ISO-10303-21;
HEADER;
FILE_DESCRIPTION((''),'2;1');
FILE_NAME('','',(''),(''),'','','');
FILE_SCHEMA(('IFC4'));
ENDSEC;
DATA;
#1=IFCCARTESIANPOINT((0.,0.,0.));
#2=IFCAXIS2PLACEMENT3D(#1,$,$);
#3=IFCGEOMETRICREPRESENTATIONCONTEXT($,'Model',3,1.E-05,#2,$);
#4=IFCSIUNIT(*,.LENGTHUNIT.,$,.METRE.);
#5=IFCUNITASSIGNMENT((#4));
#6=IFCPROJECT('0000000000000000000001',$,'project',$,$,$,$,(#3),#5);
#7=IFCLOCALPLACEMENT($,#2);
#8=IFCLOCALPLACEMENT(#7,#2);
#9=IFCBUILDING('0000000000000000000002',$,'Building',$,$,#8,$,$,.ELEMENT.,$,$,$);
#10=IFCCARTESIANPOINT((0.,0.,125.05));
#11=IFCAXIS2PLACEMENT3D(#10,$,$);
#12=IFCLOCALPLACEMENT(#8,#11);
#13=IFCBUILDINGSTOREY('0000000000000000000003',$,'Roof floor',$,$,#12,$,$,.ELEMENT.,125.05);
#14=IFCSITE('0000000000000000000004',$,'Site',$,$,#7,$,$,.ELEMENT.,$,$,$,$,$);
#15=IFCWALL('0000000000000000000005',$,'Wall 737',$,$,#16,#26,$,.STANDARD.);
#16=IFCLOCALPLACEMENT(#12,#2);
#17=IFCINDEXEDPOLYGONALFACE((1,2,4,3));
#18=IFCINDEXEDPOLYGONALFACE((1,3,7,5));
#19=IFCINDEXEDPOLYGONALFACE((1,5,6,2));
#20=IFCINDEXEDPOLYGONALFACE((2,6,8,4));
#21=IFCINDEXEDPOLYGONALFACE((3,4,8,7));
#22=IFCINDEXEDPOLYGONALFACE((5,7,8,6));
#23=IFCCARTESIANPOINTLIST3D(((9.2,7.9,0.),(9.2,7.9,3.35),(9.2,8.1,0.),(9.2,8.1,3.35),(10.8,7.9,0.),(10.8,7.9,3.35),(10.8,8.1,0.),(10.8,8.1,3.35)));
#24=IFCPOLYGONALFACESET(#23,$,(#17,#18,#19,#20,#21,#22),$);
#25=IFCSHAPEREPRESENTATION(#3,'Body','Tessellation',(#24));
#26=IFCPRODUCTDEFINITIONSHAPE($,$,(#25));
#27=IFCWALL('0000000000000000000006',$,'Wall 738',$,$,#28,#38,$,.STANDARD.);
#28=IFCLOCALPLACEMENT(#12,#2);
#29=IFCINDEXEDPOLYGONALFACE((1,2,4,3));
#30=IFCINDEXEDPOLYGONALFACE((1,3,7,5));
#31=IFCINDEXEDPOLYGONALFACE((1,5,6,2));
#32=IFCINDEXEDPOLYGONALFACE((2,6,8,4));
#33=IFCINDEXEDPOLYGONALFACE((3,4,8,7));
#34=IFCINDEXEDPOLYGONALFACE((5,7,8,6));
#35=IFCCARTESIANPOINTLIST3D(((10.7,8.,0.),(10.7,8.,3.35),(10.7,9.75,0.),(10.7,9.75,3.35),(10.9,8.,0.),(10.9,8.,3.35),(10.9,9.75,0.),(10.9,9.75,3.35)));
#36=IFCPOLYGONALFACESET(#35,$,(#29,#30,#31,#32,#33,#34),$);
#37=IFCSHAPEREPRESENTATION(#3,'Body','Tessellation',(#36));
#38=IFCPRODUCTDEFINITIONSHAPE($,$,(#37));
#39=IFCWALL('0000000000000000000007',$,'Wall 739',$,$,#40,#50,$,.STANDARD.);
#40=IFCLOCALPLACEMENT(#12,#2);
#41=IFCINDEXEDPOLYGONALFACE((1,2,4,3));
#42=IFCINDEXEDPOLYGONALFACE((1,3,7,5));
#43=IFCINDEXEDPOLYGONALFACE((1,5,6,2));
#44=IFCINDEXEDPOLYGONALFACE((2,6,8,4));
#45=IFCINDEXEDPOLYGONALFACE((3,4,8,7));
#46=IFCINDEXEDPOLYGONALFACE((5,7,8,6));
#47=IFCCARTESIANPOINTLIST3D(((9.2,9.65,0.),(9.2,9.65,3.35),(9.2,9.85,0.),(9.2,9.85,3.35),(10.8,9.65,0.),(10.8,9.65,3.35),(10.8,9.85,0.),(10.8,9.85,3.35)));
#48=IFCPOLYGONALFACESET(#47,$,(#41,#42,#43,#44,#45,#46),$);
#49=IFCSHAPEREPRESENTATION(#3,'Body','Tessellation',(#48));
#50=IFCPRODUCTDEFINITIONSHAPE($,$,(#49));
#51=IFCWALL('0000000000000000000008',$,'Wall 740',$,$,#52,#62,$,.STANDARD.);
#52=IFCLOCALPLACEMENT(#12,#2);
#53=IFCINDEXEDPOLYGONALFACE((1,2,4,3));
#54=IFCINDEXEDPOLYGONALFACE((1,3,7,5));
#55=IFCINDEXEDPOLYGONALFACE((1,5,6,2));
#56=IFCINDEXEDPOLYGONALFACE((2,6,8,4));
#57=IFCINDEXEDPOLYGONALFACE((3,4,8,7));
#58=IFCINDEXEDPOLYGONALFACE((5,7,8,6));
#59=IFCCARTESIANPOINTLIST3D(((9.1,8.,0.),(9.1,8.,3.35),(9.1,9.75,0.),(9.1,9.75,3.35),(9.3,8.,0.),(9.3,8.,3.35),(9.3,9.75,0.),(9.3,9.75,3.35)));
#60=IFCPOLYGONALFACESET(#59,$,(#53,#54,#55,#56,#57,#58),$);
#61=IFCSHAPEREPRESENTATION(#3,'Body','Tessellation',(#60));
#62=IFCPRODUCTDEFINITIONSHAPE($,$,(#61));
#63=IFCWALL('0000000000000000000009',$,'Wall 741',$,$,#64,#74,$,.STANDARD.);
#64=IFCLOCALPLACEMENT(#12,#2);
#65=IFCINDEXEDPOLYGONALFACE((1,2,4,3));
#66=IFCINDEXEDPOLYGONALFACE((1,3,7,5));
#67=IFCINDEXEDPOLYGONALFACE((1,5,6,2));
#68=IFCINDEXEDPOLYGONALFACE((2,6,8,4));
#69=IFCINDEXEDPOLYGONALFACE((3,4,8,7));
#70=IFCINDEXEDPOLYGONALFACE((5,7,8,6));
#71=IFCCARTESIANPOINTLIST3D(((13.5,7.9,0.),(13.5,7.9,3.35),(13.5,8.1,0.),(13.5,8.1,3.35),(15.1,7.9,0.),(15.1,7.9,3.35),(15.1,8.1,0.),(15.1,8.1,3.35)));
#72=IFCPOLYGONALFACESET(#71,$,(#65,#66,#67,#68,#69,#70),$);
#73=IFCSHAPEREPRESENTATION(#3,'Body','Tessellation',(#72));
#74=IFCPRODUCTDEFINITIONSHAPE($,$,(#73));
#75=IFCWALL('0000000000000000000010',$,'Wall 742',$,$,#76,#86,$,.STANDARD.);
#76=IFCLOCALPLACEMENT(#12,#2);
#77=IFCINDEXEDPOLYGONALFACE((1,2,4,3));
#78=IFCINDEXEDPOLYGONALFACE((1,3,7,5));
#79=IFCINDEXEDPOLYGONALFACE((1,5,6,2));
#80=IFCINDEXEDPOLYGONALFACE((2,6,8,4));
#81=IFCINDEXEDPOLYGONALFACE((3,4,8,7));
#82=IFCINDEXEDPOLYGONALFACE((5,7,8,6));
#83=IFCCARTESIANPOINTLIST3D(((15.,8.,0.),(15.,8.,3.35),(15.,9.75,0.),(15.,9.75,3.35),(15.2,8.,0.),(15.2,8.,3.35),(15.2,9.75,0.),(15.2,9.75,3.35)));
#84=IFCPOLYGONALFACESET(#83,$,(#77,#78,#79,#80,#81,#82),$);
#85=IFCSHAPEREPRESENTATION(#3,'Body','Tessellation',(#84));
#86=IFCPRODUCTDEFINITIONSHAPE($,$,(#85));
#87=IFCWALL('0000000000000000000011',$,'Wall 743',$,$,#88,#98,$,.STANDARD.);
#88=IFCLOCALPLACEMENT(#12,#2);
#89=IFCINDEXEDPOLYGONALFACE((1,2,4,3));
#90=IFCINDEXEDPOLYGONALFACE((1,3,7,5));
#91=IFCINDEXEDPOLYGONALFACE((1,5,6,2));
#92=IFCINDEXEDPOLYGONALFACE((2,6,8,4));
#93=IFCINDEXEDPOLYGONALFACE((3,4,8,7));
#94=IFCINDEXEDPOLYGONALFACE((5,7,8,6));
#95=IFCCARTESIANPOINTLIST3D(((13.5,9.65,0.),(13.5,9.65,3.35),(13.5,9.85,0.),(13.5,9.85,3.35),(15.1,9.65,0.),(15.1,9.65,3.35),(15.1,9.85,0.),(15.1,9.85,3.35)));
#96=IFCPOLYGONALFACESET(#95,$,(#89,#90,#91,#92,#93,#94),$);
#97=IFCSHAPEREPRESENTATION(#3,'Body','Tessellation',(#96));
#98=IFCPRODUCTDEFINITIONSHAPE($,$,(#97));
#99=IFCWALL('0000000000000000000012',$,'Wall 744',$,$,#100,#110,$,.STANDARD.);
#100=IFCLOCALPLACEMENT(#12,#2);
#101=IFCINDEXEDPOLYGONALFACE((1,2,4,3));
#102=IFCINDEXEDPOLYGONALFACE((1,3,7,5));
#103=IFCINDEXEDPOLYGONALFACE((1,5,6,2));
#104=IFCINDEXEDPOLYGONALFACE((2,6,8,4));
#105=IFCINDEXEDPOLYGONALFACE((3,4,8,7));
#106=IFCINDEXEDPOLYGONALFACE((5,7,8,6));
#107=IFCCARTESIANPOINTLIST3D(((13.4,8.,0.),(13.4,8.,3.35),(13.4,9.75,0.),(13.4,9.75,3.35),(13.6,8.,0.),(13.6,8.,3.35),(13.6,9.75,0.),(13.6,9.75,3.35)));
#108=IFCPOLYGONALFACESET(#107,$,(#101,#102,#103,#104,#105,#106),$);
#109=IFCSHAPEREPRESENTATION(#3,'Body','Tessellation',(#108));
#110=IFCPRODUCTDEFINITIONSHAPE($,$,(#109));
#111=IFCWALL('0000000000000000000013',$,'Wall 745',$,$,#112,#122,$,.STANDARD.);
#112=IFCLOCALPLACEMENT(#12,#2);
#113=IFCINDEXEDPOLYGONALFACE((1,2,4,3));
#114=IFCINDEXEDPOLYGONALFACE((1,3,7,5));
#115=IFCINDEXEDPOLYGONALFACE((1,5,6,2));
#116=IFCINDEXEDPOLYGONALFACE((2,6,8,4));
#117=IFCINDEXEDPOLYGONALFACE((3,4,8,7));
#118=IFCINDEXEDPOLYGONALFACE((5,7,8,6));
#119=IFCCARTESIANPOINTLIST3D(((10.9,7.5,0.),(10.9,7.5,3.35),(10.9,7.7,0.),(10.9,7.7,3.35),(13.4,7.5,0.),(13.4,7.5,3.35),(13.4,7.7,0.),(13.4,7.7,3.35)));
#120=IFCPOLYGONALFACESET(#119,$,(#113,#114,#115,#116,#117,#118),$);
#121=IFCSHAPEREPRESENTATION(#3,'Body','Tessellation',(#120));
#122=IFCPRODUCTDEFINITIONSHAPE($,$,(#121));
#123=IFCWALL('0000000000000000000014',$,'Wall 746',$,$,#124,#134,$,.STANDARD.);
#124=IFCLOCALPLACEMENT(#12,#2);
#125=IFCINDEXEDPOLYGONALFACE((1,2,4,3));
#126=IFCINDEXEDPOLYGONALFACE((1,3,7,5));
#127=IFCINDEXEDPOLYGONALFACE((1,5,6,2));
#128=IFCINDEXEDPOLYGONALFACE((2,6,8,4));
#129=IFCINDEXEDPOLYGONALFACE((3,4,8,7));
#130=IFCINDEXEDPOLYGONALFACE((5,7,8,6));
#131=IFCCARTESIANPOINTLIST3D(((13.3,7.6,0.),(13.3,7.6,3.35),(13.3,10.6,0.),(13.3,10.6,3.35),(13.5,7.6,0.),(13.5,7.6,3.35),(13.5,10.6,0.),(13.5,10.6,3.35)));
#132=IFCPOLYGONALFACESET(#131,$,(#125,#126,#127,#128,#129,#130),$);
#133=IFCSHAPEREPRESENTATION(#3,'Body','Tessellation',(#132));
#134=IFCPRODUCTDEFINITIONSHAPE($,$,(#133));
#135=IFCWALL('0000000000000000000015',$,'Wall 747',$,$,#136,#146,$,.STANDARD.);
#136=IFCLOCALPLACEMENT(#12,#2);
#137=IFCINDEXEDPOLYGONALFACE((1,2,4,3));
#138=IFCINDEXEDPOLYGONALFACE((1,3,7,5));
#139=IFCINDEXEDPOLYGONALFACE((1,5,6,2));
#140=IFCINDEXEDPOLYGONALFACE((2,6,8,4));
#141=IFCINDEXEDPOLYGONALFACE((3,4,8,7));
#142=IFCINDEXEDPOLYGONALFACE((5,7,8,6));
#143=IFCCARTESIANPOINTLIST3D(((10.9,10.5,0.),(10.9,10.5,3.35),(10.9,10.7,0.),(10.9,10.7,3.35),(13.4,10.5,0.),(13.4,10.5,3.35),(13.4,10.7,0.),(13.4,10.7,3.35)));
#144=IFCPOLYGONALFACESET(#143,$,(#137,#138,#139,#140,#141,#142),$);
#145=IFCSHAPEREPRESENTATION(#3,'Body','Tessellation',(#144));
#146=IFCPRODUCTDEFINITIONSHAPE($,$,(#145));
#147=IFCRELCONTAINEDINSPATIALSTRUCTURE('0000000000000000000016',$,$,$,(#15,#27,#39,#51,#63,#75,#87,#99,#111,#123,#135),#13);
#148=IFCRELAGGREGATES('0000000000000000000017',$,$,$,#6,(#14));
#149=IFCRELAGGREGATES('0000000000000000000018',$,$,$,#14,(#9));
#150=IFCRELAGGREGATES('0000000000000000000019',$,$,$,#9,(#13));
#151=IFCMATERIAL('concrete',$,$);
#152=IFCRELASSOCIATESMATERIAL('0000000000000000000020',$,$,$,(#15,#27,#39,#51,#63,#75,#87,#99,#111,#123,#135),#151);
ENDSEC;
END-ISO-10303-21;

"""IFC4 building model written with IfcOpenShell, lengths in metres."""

from ifc_helpers import new_model, si_unit, frame, frame_2d, origin, place, context, project, spatial, rectangle, extrude, material, element, save


model = new_model("IFC4")

# Units and contexts
model_context = context("Model", 3, precision=1e-05, world=origin())
ifc_project = project(units=[si_unit("LENGTHUNIT", "METRE")], contexts=[model_context])

# Site, building, storey
site_placement = place(None, origin())
site = spatial("IfcSite", under=ifc_project, at=site_placement, Name="Site", CompositionType="ELEMENT")
building_placement = place(site_placement, origin())
building = spatial("IfcBuilding", under=site, at=building_placement, Name="Building", CompositionType="ELEMENT")
storey_placement = place(building_placement, frame((0.0, 0.0, 125.05)))
storey = spatial("IfcBuildingStorey", under=building, at=storey_placement, Name="Roof floor", CompositionType="ELEMENT", Elevation=125.05)

# Shared definitions
ifc_material = material(Name="concrete")

# Walls
wall_1_placement = place(storey_placement, frame((9.2, 8.0, 0.0), z_axis=(0.0, 0.0, 1.0), x_axis=(1.0, 0.0, 0.0)))
element("IfcWall", 1, at=wall_1_placement, inside=storey, material=ifc_material, Name="Wall 737", PredefinedType="STANDARD", context=model_context, shape_type="SweptSolid", body=[
    extrude(rectangle(XDim=1.6, YDim=0.2, at=frame_2d((0.8, 0.0))), origin(), (0.0, 0.0, 1.0), 3.35),
])
wall_2_placement = place(storey_placement, frame((10.8, 8.0, 0.0), z_axis=(0.0, 0.0, 1.0), x_axis=(0.0, 1.0, 0.0)))
element("IfcWall", 2, at=wall_2_placement, inside=storey, material=ifc_material, Name="Wall 738", PredefinedType="STANDARD", context=model_context, shape_type="SweptSolid", body=[
    extrude(rectangle(XDim=1.75, YDim=0.2, at=frame_2d((0.875, 0.0))), origin(), (0.0, 0.0, 1.0), 3.35),
])
wall_3_placement = place(storey_placement, frame((10.8, 9.75, 0.0), z_axis=(0.0, 0.0, 1.0), x_axis=(-1.0, 0.0, 0.0)))
element("IfcWall", 3, at=wall_3_placement, inside=storey, material=ifc_material, Name="Wall 739", PredefinedType="STANDARD", context=model_context, shape_type="SweptSolid", body=[
    extrude(rectangle(XDim=1.6, YDim=0.2, at=frame_2d((0.8, 0.0))), origin(), (0.0, 0.0, 1.0), 3.35),
])
wall_4_placement = place(storey_placement, frame((9.2, 9.75, 0.0), z_axis=(0.0, 0.0, 1.0), x_axis=(0.0, -1.0, 0.0)))
element("IfcWall", 4, at=wall_4_placement, inside=storey, material=ifc_material, Name="Wall 740", PredefinedType="STANDARD", context=model_context, shape_type="SweptSolid", body=[
    extrude(rectangle(XDim=1.75, YDim=0.2, at=frame_2d((0.875, 0.0))), origin(), (0.0, 0.0, 1.0), 3.35),
])
wall_5_placement = place(storey_placement, frame((13.5, 8.0, 0.0), z_axis=(0.0, 0.0, 1.0), x_axis=(1.0, 0.0, 0.0)))
element("IfcWall", 5, at=wall_5_placement, inside=storey, material=ifc_material, Name="Wall 741", PredefinedType="STANDARD", context=model_context, shape_type="SweptSolid", body=[
    extrude(rectangle(XDim=1.6, YDim=0.2, at=frame_2d((0.8, 0.0))), origin(), (0.0, 0.0, 1.0), 3.35),
])
wall_6_placement = place(storey_placement, frame((15.1, 8.0, 0.0), z_axis=(0.0, 0.0, 1.0), x_axis=(0.0, 1.0, 0.0)))
element("IfcWall", 6, at=wall_6_placement, inside=storey, material=ifc_material, Name="Wall 742", PredefinedType="STANDARD", context=model_context, shape_type="SweptSolid", body=[
    extrude(rectangle(XDim=1.75, YDim=0.2, at=frame_2d((0.875, 0.0))), origin(), (0.0, 0.0, 1.0), 3.35),
])
wall_7_placement = place(storey_placement, frame((15.1, 9.75, 0.0), z_axis=(0.0, 0.0, 1.0), x_axis=(-1.0, 0.0, 0.0)))
element("IfcWall", 7, at=wall_7_placement, inside=storey, material=ifc_material, Name="Wall 743", PredefinedType="STANDARD", context=model_context, shape_type="SweptSolid", body=[
    extrude(rectangle(XDim=1.6, YDim=0.2, at=frame_2d((0.8, 0.0))), origin(), (0.0, 0.0, 1.0), 3.35),
])
wall_8_placement = place(storey_placement, frame((13.5, 9.75, 0.0), z_axis=(0.0, 0.0, 1.0), x_axis=(0.0, -1.0, 0.0)))
element("IfcWall", 8, at=wall_8_placement, inside=storey, material=ifc_material, Name="Wall 744", PredefinedType="STANDARD", context=model_context, shape_type="SweptSolid", body=[
    extrude(rectangle(XDim=1.75, YDim=0.2, at=frame_2d((0.875, 0.0))), origin(), (0.0, 0.0, 1.0), 3.35),
])
wall_9_placement = place(storey_placement, frame((10.9, 7.6, 0.0), z_axis=(0.0, 0.0, 1.0), x_axis=(1.0, 0.0, 0.0)))
element("IfcWall", 9, at=wall_9_placement, inside=storey, material=ifc_material, Name="Wall 745", PredefinedType="STANDARD", context=model_context, shape_type="SweptSolid", body=[
    extrude(rectangle(XDim=2.5, YDim=0.2, at=frame_2d((1.25, 0.0))), origin(), (0.0, 0.0, 1.0), 3.35),
])
wall_10_placement = place(storey_placement, frame((13.4, 7.6, 0.0), z_axis=(0.0, 0.0, 1.0), x_axis=(0.0, 1.0, 0.0)))
element("IfcWall", 10, at=wall_10_placement, inside=storey, material=ifc_material, Name="Wall 746", PredefinedType="STANDARD", context=model_context, shape_type="SweptSolid", body=[
    extrude(rectangle(XDim=3.0, YDim=0.2, at=frame_2d((1.5, 0.0))), origin(), (0.0, 0.0, 1.0), 3.35),
])
wall_11_placement = place(storey_placement, frame((13.4, 10.6, 0.0), z_axis=(0.0, 0.0, 1.0), x_axis=(-1.0, 0.0, 0.0)))
element("IfcWall", 11, at=wall_11_placement, inside=storey, material=ifc_material, Name="Wall 747", PredefinedType="STANDARD", context=model_context, shape_type="SweptSolid", body=[
    extrude(rectangle(XDim=2.5, YDim=0.2, at=frame_2d((1.25, 0.0))), origin(), (0.0, 0.0, 1.0), 3.35),
])

save(model, "model.ifc")
